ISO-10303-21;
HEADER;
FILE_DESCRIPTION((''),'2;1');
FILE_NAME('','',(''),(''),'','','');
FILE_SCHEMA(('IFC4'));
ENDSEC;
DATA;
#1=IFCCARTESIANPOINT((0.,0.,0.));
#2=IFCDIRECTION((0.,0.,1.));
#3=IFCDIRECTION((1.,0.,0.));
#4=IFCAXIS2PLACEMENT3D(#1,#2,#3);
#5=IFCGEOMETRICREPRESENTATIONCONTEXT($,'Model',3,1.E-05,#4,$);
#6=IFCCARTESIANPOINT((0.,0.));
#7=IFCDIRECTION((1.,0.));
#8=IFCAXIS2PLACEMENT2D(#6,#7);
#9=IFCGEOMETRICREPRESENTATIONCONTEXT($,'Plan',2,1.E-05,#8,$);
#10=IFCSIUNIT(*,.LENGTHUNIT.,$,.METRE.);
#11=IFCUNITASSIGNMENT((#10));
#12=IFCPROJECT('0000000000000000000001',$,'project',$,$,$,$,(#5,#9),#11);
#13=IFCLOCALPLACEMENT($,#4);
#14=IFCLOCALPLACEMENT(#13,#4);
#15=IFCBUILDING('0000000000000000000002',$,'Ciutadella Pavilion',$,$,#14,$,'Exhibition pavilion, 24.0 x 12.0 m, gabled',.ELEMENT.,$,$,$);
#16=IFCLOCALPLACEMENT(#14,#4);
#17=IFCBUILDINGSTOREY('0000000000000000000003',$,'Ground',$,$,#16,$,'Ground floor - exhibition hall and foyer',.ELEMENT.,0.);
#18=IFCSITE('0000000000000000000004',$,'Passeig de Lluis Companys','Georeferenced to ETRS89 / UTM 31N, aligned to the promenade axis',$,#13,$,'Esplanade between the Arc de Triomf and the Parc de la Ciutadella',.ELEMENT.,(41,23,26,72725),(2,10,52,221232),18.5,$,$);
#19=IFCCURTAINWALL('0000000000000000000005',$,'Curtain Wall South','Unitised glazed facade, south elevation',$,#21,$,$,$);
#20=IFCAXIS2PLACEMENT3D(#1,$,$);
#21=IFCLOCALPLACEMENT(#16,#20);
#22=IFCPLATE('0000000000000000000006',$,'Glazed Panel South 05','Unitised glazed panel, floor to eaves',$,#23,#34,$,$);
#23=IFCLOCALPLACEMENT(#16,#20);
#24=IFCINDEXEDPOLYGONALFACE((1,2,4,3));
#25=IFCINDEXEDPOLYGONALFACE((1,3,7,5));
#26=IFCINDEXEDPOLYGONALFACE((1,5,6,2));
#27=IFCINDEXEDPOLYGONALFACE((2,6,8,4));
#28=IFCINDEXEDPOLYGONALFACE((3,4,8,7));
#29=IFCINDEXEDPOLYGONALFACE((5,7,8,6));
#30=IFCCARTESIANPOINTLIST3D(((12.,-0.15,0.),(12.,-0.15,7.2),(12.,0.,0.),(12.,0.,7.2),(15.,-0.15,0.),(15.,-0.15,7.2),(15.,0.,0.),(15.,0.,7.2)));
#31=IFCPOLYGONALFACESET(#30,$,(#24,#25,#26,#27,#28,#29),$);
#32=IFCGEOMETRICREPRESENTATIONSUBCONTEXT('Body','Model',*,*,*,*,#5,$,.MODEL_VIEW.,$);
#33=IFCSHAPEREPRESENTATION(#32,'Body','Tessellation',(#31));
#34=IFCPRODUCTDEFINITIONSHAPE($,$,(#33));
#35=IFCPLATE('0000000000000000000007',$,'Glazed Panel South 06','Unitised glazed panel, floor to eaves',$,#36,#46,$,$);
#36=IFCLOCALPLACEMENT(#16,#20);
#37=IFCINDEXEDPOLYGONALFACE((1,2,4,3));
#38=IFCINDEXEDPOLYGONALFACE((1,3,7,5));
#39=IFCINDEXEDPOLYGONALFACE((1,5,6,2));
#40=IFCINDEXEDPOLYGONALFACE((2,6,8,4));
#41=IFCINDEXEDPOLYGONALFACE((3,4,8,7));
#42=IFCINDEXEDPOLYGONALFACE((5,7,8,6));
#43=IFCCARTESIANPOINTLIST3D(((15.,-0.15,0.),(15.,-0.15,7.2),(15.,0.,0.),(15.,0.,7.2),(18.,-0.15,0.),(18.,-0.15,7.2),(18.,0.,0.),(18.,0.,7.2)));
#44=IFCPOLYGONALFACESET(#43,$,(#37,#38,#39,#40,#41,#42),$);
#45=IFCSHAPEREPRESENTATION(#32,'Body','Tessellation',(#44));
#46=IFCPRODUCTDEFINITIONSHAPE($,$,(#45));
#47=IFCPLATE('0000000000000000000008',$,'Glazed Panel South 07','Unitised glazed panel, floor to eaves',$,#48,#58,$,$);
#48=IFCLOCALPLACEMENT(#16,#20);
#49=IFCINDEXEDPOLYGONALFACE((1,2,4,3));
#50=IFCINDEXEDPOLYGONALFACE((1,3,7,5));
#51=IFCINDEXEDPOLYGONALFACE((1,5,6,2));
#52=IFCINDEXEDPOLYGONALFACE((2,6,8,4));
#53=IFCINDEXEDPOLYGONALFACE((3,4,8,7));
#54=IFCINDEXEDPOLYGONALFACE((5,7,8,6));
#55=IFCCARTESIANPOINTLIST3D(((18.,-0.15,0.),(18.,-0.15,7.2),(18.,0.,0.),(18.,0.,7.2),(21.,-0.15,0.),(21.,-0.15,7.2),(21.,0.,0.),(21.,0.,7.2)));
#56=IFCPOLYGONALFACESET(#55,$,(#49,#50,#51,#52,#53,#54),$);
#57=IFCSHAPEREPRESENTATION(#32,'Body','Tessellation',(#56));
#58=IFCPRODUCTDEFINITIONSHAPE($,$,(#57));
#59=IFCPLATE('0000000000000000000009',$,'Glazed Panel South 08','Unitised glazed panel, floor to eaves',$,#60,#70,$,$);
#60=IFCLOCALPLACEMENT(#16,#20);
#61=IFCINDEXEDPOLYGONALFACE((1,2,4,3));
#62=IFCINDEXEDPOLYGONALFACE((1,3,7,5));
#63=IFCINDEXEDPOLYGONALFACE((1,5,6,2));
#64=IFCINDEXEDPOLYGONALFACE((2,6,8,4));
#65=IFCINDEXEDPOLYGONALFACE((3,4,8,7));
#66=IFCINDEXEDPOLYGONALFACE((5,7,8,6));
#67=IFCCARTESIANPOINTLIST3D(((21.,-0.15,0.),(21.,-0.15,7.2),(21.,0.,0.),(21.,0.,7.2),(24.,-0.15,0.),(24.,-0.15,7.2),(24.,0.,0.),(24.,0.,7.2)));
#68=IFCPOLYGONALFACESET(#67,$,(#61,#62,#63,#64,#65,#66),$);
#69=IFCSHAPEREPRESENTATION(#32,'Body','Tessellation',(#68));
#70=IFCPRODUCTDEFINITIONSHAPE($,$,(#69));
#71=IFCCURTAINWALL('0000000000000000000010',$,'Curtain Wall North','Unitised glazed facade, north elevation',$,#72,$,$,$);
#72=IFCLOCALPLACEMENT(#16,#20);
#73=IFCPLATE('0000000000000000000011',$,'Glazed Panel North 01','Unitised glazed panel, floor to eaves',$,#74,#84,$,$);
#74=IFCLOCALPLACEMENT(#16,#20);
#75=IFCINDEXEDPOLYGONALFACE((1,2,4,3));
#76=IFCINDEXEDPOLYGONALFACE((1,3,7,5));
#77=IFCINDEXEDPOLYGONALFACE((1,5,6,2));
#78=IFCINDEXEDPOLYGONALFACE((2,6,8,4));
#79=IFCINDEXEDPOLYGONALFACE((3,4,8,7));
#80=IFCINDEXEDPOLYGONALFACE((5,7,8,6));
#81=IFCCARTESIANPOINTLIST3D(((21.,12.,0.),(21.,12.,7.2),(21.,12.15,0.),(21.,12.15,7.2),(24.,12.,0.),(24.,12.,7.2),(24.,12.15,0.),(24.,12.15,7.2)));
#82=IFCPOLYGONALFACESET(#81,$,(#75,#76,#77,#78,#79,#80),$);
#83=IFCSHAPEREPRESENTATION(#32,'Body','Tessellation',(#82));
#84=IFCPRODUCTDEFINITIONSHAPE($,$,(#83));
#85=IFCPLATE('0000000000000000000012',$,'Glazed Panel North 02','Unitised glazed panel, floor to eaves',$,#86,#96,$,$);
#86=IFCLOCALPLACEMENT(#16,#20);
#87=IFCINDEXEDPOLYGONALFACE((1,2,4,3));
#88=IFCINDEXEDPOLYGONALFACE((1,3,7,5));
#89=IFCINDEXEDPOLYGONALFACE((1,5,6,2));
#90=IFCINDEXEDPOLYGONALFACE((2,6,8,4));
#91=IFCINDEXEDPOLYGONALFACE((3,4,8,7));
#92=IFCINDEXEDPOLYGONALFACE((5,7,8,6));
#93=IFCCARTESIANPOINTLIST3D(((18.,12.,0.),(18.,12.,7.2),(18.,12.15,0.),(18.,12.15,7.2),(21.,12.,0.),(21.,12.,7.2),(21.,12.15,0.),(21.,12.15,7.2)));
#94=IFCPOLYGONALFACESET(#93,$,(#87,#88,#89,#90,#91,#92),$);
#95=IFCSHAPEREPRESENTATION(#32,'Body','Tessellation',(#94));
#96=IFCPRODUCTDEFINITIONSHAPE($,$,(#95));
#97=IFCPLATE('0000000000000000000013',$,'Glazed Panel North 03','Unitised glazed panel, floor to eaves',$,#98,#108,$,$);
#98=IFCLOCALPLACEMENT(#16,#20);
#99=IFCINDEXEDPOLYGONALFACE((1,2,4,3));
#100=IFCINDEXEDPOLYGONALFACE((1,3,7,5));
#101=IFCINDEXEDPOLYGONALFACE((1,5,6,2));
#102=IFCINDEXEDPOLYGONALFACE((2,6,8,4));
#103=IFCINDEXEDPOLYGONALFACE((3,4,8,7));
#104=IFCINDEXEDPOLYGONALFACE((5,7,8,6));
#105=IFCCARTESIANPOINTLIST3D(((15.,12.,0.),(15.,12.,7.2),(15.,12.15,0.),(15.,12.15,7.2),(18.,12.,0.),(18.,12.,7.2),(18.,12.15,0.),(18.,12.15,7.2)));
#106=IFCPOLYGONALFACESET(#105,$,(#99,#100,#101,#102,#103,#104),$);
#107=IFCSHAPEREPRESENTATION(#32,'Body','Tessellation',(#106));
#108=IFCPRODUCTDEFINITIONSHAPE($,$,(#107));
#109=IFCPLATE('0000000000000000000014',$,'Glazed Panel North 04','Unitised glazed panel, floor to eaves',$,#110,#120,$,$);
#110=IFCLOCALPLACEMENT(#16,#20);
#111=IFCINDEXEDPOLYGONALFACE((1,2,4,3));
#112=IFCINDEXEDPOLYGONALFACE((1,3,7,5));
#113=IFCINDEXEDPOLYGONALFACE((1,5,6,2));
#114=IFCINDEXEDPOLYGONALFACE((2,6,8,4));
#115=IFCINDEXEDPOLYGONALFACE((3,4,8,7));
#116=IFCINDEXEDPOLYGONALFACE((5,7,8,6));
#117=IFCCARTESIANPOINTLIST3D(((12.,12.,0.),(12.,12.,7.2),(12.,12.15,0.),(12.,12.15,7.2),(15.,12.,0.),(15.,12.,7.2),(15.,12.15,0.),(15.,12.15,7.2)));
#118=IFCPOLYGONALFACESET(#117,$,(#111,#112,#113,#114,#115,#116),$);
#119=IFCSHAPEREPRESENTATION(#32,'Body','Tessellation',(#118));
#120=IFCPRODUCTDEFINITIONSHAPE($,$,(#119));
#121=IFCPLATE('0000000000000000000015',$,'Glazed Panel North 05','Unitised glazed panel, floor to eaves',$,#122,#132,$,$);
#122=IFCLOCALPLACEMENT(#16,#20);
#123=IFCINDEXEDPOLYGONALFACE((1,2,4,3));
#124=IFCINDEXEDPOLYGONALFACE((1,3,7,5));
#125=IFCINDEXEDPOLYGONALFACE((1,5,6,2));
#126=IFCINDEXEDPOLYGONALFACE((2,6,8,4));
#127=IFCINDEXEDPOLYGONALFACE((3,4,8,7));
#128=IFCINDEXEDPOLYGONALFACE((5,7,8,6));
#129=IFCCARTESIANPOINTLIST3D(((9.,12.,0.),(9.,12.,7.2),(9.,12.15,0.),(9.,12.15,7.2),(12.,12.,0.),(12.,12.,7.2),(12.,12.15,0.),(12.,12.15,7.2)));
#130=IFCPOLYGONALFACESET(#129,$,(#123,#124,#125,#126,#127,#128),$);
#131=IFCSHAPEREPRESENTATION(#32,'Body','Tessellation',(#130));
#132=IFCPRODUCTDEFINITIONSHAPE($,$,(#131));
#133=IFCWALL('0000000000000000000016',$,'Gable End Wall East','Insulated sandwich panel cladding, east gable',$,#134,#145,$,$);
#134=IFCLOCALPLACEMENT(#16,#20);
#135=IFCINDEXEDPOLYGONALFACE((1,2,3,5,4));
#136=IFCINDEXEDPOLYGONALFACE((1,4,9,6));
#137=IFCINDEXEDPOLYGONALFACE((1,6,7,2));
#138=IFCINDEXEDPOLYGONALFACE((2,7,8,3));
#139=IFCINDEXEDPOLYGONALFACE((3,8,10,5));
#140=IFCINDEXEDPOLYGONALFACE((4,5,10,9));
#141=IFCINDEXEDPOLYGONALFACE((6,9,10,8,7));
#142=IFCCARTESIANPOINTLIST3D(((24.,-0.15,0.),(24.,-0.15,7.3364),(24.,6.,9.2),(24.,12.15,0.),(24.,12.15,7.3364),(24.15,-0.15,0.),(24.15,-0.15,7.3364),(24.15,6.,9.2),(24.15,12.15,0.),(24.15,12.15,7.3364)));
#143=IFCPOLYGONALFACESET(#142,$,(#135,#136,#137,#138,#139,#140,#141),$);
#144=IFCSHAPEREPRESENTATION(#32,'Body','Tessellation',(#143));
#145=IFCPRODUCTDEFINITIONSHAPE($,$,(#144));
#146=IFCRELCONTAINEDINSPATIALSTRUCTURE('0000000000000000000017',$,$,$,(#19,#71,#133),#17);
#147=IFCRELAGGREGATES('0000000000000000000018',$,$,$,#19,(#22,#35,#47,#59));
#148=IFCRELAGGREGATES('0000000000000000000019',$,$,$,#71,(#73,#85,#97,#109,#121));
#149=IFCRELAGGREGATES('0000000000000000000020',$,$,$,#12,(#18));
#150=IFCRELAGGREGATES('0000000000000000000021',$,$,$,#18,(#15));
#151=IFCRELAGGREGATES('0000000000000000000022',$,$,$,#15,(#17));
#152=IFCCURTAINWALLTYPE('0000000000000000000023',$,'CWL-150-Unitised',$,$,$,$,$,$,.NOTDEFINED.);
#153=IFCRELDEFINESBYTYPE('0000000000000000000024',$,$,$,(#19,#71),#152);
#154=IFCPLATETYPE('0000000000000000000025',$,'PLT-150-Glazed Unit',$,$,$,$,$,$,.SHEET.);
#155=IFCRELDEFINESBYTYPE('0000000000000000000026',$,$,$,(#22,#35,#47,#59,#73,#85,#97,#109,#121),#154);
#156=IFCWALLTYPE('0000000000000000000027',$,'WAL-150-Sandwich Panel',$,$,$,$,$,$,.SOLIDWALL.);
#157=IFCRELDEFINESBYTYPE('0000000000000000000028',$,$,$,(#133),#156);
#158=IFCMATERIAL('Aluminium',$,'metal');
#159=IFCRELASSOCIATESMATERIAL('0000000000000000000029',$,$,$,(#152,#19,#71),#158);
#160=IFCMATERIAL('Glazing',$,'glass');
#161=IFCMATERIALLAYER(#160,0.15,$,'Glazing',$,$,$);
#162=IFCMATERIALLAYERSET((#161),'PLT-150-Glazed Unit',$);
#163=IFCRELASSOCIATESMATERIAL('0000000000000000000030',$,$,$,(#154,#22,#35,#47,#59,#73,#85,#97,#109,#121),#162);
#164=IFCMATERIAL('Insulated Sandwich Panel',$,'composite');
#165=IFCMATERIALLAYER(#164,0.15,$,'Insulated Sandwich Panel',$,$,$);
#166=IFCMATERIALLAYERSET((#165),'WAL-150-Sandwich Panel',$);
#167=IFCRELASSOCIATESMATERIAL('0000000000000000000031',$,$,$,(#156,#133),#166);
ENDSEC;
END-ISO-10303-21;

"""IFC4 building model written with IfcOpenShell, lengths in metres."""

from ifc_helpers import new_model, si_unit, frame, origin_with_axes, origin_2d_with_axis, place, context, subcontext, project, spatial, line, indexed_curve, outline, extrude, material, layer, layer_set, layer_usage, type_object, element, aggregate, save


model = new_model("IFC4")

# Units and contexts
model_context = context("Model", 3, precision=1e-05, world=origin_with_axes())
plan_context = context("Plan", 2, precision=1e-05, world=origin_2d_with_axis())
body_context = subcontext(model_context, "Body", "Model", "MODEL_VIEW")
ifc_project = project(units=[si_unit("LENGTHUNIT", "METRE")], contexts=[model_context, plan_context])

# Site, building, storey
site_placement = place(None, origin_with_axes())
site = spatial("IfcSite", under=ifc_project, at=site_placement, Name="Passeig de Lluis Companys", Description="Georeferenced to ETRS89 / UTM 31N, aligned to the promenade axis", LongName="Esplanade between the Arc de Triomf and the Parc de la Ciutadella", CompositionType="ELEMENT", RefLatitude=(41, 23, 26, 72725), RefLongitude=(2, 10, 52, 221232), RefElevation=18.5)
building_placement = place(site_placement, origin_with_axes())
building = spatial("IfcBuilding", under=site, at=building_placement, Name="Ciutadella Pavilion", LongName="Exhibition pavilion, 24.0 x 12.0 m, gabled", CompositionType="ELEMENT")
storey_placement = place(building_placement, origin_with_axes())
storey = spatial("IfcBuildingStorey", under=building, at=storey_placement, Name="Ground", LongName="Ground floor - exhibition hall and foyer", CompositionType="ELEMENT", Elevation=0.0)

# Curtain walls, plates
ifc_material_1 = material(Name="Aluminium", Category="metal")
curtain_wall_type = type_object("IfcCurtainWallType", Name="CWL-150-Unitised", PredefinedType="NOTDEFINED", material=ifc_material_1)
curtain_wall_1_placement = place(storey_placement, frame((0.0, -0.15, 0.0), z_axis=(0.0, 0.0, 1.0), x_axis=(1.0, 0.0, 0.0)))
curtain_wall_1 = element("IfcCurtainWall", 1, at=curtain_wall_1_placement, inside=storey, type_object=curtain_wall_type, material=ifc_material_1, Name="Curtain Wall South", Description="Unitised glazed facade, south elevation")
ifc_material_2 = material(Name="Glazing", Category="glass")
ifc_layer_1 = layer(ifc_material_2, 0.15, Name="Glazing")
ifc_layer_set_1 = layer_set([ifc_layer_1], Name="PLT-150-Glazed Unit")
ifc_layer_usage_1 = layer_usage(ifc_layer_set_1, "AXIS2", "POSITIVE", 0.0)
plate_type = type_object("IfcPlateType", Name="PLT-150-Glazed Unit", PredefinedType="SHEET", material=ifc_layer_set_1)
plate_1_placement = place(curtain_wall_1_placement, frame((12.0, 0.0, 0.0), z_axis=(0.0, 0.0, 1.0), x_axis=(1.0, 0.0, 0.0)))
plate_1 = element("IfcPlate", 2, at=plate_1_placement, type_object=plate_type, material=ifc_layer_usage_1, Name="Glazed Panel South 05", Description="Unitised glazed panel, floor to eaves", context=body_context, shape_type="SweptSolid", body=[
    extrude(outline(indexed_curve([(0.0, 0.0), (3.0, 0.0), (3.0, 0.15), (0.0, 0.15)], segments=[line(1, 2, 3, 4, 1)])), origin_with_axes(), (0.0, 0.0, 1.0), 7.2),
])
ifc_layer_usage_2 = layer_usage(ifc_layer_set_1, "AXIS2", "POSITIVE", 0.0)
plate_2_placement = place(curtain_wall_1_placement, frame((15.0, 0.0, 0.0), z_axis=(0.0, 0.0, 1.0), x_axis=(1.0, 0.0, 0.0)))
plate_2 = element("IfcPlate", 3, at=plate_2_placement, type_object=plate_type, material=ifc_layer_usage_2, Name="Glazed Panel South 06", Description="Unitised glazed panel, floor to eaves", context=body_context, shape_type="SweptSolid", body=[
    extrude(outline(indexed_curve([(0.0, 0.0), (3.0, 0.0), (3.0, 0.15), (0.0, 0.15)], segments=[line(1, 2, 3, 4, 1)])), origin_with_axes(), (0.0, 0.0, 1.0), 7.2),
])
ifc_layer_usage_3 = layer_usage(ifc_layer_set_1, "AXIS2", "POSITIVE", 0.0)
plate_3_placement = place(curtain_wall_1_placement, frame((18.0, 0.0, 0.0), z_axis=(0.0, 0.0, 1.0), x_axis=(1.0, 0.0, 0.0)))
plate_3 = element("IfcPlate", 4, at=plate_3_placement, type_object=plate_type, material=ifc_layer_usage_3, Name="Glazed Panel South 07", Description="Unitised glazed panel, floor to eaves", context=body_context, shape_type="SweptSolid", body=[
    extrude(outline(indexed_curve([(0.0, 0.0), (3.0, 0.0), (3.0, 0.15), (0.0, 0.15)], segments=[line(1, 2, 3, 4, 1)])), origin_with_axes(), (0.0, 0.0, 1.0), 7.2),
])
ifc_layer_usage_4 = layer_usage(ifc_layer_set_1, "AXIS2", "POSITIVE", 0.0)
plate_4_placement = place(curtain_wall_1_placement, frame((21.0, 0.0, 0.0), z_axis=(0.0, 0.0, 1.0), x_axis=(1.0, 0.0, 0.0)))
plate_4 = element("IfcPlate", 5, at=plate_4_placement, type_object=plate_type, material=ifc_layer_usage_4, Name="Glazed Panel South 08", Description="Unitised glazed panel, floor to eaves", context=body_context, shape_type="SweptSolid", body=[
    extrude(outline(indexed_curve([(0.0, 0.0), (3.0, 0.0), (3.0, 0.15), (0.0, 0.15)], segments=[line(1, 2, 3, 4, 1)])), origin_with_axes(), (0.0, 0.0, 1.0), 7.2),
])
aggregate(curtain_wall_1, [plate_1, plate_2, plate_3, plate_4])
curtain_wall_2_placement = place(storey_placement, frame((24.0, 12.15, 0.0), z_axis=(0.0, 0.0, 1.0), x_axis=(-1.0, 0.0, 0.0)))
curtain_wall_2 = element("IfcCurtainWall", 6, at=curtain_wall_2_placement, inside=storey, type_object=curtain_wall_type, material=ifc_material_1, Name="Curtain Wall North", Description="Unitised glazed facade, north elevation")
ifc_layer_usage_5 = layer_usage(ifc_layer_set_1, "AXIS2", "POSITIVE", 0.0)
plate_5_placement = place(curtain_wall_2_placement, origin_with_axes())
plate_5 = element("IfcPlate", 7, at=plate_5_placement, type_object=plate_type, material=ifc_layer_usage_5, Name="Glazed Panel North 01", Description="Unitised glazed panel, floor to eaves", context=body_context, shape_type="SweptSolid", body=[
    extrude(outline(indexed_curve([(0.0, 0.0), (3.0, 0.0), (3.0, 0.15), (0.0, 0.15)], segments=[line(1, 2, 3, 4, 1)])), origin_with_axes(), (0.0, 0.0, 1.0), 7.2),
])
ifc_layer_usage_6 = layer_usage(ifc_layer_set_1, "AXIS2", "POSITIVE", 0.0)
plate_6_placement = place(curtain_wall_2_placement, frame((3.0, 0.0, 0.0), z_axis=(0.0, 0.0, 1.0), x_axis=(1.0, 0.0, 0.0)))
plate_6 = element("IfcPlate", 8, at=plate_6_placement, type_object=plate_type, material=ifc_layer_usage_6, Name="Glazed Panel North 02", Description="Unitised glazed panel, floor to eaves", context=body_context, shape_type="SweptSolid", body=[
    extrude(outline(indexed_curve([(0.0, 0.0), (3.0, 0.0), (3.0, 0.15), (0.0, 0.15)], segments=[line(1, 2, 3, 4, 1)])), origin_with_axes(), (0.0, 0.0, 1.0), 7.2),
])
ifc_layer_usage_7 = layer_usage(ifc_layer_set_1, "AXIS2", "POSITIVE", 0.0)
plate_7_placement = place(curtain_wall_2_placement, frame((6.0, 0.0, 0.0), z_axis=(0.0, 0.0, 1.0), x_axis=(1.0, 0.0, 0.0)))
plate_7 = element("IfcPlate", 9, at=plate_7_placement, type_object=plate_type, material=ifc_layer_usage_7, Name="Glazed Panel North 03", Description="Unitised glazed panel, floor to eaves", context=body_context, shape_type="SweptSolid", body=[
    extrude(outline(indexed_curve([(0.0, 0.0), (3.0, 0.0), (3.0, 0.15), (0.0, 0.15)], segments=[line(1, 2, 3, 4, 1)])), origin_with_axes(), (0.0, 0.0, 1.0), 7.2),
])
ifc_layer_usage_8 = layer_usage(ifc_layer_set_1, "AXIS2", "POSITIVE", 0.0)
plate_8_placement = place(curtain_wall_2_placement, frame((9.0, 0.0, 0.0), z_axis=(0.0, 0.0, 1.0), x_axis=(1.0, 0.0, 0.0)))
plate_8 = element("IfcPlate", 10, at=plate_8_placement, type_object=plate_type, material=ifc_layer_usage_8, Name="Glazed Panel North 04", Description="Unitised glazed panel, floor to eaves", context=body_context, shape_type="SweptSolid", body=[
    extrude(outline(indexed_curve([(0.0, 0.0), (3.0, 0.0), (3.0, 0.15), (0.0, 0.15)], segments=[line(1, 2, 3, 4, 1)])), origin_with_axes(), (0.0, 0.0, 1.0), 7.2),
])
ifc_layer_usage_9 = layer_usage(ifc_layer_set_1, "AXIS2", "POSITIVE", 0.0)
plate_9_placement = place(curtain_wall_2_placement, frame((12.0, 0.0, 0.0), z_axis=(0.0, 0.0, 1.0), x_axis=(1.0, 0.0, 0.0)))
plate_9 = element("IfcPlate", 11, at=plate_9_placement, type_object=plate_type, material=ifc_layer_usage_9, Name="Glazed Panel North 05", Description="Unitised glazed panel, floor to eaves", context=body_context, shape_type="SweptSolid", body=[
    extrude(outline(indexed_curve([(0.0, 0.0), (3.0, 0.0), (3.0, 0.15), (0.0, 0.15)], segments=[line(1, 2, 3, 4, 1)])), origin_with_axes(), (0.0, 0.0, 1.0), 7.2),
])
aggregate(curtain_wall_2, [plate_5, plate_6, plate_7, plate_8, plate_9])

# Wall
ifc_material_3 = material(Name="Insulated Sandwich Panel", Category="composite")
ifc_layer_2 = layer(ifc_material_3, 0.15, Name="Insulated Sandwich Panel")
ifc_layer_set_2 = layer_set([ifc_layer_2], Name="WAL-150-Sandwich Panel")
ifc_layer_usage_10 = layer_usage(ifc_layer_set_2, "AXIS2", "POSITIVE", 0.0)
wall_type = type_object("IfcWallType", Name="WAL-150-Sandwich Panel", PredefinedType="SOLIDWALL", material=ifc_layer_set_2)
wall_placement = place(storey_placement, frame((24.0, -0.15, 0.0), z_axis=(1.0, 0.0, 0.0), x_axis=(0.0, 1.0, 0.0)))
element("IfcWall", 12, at=wall_placement, inside=storey, type_object=wall_type, material=ifc_layer_usage_10, Name="Gable End Wall East", Description="Insulated sandwich panel cladding, east gable", context=body_context, shape_type="SweptSolid", body=[
    extrude(outline(indexed_curve([(0.0, 0.0), (12.3, 0.0), (12.3, 7.3364), (6.15, 9.2), (0.0, 7.3364)], segments=[line(1, 2, 3, 4, 5, 1)])), origin_with_axes(), (0.0, 0.0, 1.0), 0.15),
])

save(model, "model.ifc")
